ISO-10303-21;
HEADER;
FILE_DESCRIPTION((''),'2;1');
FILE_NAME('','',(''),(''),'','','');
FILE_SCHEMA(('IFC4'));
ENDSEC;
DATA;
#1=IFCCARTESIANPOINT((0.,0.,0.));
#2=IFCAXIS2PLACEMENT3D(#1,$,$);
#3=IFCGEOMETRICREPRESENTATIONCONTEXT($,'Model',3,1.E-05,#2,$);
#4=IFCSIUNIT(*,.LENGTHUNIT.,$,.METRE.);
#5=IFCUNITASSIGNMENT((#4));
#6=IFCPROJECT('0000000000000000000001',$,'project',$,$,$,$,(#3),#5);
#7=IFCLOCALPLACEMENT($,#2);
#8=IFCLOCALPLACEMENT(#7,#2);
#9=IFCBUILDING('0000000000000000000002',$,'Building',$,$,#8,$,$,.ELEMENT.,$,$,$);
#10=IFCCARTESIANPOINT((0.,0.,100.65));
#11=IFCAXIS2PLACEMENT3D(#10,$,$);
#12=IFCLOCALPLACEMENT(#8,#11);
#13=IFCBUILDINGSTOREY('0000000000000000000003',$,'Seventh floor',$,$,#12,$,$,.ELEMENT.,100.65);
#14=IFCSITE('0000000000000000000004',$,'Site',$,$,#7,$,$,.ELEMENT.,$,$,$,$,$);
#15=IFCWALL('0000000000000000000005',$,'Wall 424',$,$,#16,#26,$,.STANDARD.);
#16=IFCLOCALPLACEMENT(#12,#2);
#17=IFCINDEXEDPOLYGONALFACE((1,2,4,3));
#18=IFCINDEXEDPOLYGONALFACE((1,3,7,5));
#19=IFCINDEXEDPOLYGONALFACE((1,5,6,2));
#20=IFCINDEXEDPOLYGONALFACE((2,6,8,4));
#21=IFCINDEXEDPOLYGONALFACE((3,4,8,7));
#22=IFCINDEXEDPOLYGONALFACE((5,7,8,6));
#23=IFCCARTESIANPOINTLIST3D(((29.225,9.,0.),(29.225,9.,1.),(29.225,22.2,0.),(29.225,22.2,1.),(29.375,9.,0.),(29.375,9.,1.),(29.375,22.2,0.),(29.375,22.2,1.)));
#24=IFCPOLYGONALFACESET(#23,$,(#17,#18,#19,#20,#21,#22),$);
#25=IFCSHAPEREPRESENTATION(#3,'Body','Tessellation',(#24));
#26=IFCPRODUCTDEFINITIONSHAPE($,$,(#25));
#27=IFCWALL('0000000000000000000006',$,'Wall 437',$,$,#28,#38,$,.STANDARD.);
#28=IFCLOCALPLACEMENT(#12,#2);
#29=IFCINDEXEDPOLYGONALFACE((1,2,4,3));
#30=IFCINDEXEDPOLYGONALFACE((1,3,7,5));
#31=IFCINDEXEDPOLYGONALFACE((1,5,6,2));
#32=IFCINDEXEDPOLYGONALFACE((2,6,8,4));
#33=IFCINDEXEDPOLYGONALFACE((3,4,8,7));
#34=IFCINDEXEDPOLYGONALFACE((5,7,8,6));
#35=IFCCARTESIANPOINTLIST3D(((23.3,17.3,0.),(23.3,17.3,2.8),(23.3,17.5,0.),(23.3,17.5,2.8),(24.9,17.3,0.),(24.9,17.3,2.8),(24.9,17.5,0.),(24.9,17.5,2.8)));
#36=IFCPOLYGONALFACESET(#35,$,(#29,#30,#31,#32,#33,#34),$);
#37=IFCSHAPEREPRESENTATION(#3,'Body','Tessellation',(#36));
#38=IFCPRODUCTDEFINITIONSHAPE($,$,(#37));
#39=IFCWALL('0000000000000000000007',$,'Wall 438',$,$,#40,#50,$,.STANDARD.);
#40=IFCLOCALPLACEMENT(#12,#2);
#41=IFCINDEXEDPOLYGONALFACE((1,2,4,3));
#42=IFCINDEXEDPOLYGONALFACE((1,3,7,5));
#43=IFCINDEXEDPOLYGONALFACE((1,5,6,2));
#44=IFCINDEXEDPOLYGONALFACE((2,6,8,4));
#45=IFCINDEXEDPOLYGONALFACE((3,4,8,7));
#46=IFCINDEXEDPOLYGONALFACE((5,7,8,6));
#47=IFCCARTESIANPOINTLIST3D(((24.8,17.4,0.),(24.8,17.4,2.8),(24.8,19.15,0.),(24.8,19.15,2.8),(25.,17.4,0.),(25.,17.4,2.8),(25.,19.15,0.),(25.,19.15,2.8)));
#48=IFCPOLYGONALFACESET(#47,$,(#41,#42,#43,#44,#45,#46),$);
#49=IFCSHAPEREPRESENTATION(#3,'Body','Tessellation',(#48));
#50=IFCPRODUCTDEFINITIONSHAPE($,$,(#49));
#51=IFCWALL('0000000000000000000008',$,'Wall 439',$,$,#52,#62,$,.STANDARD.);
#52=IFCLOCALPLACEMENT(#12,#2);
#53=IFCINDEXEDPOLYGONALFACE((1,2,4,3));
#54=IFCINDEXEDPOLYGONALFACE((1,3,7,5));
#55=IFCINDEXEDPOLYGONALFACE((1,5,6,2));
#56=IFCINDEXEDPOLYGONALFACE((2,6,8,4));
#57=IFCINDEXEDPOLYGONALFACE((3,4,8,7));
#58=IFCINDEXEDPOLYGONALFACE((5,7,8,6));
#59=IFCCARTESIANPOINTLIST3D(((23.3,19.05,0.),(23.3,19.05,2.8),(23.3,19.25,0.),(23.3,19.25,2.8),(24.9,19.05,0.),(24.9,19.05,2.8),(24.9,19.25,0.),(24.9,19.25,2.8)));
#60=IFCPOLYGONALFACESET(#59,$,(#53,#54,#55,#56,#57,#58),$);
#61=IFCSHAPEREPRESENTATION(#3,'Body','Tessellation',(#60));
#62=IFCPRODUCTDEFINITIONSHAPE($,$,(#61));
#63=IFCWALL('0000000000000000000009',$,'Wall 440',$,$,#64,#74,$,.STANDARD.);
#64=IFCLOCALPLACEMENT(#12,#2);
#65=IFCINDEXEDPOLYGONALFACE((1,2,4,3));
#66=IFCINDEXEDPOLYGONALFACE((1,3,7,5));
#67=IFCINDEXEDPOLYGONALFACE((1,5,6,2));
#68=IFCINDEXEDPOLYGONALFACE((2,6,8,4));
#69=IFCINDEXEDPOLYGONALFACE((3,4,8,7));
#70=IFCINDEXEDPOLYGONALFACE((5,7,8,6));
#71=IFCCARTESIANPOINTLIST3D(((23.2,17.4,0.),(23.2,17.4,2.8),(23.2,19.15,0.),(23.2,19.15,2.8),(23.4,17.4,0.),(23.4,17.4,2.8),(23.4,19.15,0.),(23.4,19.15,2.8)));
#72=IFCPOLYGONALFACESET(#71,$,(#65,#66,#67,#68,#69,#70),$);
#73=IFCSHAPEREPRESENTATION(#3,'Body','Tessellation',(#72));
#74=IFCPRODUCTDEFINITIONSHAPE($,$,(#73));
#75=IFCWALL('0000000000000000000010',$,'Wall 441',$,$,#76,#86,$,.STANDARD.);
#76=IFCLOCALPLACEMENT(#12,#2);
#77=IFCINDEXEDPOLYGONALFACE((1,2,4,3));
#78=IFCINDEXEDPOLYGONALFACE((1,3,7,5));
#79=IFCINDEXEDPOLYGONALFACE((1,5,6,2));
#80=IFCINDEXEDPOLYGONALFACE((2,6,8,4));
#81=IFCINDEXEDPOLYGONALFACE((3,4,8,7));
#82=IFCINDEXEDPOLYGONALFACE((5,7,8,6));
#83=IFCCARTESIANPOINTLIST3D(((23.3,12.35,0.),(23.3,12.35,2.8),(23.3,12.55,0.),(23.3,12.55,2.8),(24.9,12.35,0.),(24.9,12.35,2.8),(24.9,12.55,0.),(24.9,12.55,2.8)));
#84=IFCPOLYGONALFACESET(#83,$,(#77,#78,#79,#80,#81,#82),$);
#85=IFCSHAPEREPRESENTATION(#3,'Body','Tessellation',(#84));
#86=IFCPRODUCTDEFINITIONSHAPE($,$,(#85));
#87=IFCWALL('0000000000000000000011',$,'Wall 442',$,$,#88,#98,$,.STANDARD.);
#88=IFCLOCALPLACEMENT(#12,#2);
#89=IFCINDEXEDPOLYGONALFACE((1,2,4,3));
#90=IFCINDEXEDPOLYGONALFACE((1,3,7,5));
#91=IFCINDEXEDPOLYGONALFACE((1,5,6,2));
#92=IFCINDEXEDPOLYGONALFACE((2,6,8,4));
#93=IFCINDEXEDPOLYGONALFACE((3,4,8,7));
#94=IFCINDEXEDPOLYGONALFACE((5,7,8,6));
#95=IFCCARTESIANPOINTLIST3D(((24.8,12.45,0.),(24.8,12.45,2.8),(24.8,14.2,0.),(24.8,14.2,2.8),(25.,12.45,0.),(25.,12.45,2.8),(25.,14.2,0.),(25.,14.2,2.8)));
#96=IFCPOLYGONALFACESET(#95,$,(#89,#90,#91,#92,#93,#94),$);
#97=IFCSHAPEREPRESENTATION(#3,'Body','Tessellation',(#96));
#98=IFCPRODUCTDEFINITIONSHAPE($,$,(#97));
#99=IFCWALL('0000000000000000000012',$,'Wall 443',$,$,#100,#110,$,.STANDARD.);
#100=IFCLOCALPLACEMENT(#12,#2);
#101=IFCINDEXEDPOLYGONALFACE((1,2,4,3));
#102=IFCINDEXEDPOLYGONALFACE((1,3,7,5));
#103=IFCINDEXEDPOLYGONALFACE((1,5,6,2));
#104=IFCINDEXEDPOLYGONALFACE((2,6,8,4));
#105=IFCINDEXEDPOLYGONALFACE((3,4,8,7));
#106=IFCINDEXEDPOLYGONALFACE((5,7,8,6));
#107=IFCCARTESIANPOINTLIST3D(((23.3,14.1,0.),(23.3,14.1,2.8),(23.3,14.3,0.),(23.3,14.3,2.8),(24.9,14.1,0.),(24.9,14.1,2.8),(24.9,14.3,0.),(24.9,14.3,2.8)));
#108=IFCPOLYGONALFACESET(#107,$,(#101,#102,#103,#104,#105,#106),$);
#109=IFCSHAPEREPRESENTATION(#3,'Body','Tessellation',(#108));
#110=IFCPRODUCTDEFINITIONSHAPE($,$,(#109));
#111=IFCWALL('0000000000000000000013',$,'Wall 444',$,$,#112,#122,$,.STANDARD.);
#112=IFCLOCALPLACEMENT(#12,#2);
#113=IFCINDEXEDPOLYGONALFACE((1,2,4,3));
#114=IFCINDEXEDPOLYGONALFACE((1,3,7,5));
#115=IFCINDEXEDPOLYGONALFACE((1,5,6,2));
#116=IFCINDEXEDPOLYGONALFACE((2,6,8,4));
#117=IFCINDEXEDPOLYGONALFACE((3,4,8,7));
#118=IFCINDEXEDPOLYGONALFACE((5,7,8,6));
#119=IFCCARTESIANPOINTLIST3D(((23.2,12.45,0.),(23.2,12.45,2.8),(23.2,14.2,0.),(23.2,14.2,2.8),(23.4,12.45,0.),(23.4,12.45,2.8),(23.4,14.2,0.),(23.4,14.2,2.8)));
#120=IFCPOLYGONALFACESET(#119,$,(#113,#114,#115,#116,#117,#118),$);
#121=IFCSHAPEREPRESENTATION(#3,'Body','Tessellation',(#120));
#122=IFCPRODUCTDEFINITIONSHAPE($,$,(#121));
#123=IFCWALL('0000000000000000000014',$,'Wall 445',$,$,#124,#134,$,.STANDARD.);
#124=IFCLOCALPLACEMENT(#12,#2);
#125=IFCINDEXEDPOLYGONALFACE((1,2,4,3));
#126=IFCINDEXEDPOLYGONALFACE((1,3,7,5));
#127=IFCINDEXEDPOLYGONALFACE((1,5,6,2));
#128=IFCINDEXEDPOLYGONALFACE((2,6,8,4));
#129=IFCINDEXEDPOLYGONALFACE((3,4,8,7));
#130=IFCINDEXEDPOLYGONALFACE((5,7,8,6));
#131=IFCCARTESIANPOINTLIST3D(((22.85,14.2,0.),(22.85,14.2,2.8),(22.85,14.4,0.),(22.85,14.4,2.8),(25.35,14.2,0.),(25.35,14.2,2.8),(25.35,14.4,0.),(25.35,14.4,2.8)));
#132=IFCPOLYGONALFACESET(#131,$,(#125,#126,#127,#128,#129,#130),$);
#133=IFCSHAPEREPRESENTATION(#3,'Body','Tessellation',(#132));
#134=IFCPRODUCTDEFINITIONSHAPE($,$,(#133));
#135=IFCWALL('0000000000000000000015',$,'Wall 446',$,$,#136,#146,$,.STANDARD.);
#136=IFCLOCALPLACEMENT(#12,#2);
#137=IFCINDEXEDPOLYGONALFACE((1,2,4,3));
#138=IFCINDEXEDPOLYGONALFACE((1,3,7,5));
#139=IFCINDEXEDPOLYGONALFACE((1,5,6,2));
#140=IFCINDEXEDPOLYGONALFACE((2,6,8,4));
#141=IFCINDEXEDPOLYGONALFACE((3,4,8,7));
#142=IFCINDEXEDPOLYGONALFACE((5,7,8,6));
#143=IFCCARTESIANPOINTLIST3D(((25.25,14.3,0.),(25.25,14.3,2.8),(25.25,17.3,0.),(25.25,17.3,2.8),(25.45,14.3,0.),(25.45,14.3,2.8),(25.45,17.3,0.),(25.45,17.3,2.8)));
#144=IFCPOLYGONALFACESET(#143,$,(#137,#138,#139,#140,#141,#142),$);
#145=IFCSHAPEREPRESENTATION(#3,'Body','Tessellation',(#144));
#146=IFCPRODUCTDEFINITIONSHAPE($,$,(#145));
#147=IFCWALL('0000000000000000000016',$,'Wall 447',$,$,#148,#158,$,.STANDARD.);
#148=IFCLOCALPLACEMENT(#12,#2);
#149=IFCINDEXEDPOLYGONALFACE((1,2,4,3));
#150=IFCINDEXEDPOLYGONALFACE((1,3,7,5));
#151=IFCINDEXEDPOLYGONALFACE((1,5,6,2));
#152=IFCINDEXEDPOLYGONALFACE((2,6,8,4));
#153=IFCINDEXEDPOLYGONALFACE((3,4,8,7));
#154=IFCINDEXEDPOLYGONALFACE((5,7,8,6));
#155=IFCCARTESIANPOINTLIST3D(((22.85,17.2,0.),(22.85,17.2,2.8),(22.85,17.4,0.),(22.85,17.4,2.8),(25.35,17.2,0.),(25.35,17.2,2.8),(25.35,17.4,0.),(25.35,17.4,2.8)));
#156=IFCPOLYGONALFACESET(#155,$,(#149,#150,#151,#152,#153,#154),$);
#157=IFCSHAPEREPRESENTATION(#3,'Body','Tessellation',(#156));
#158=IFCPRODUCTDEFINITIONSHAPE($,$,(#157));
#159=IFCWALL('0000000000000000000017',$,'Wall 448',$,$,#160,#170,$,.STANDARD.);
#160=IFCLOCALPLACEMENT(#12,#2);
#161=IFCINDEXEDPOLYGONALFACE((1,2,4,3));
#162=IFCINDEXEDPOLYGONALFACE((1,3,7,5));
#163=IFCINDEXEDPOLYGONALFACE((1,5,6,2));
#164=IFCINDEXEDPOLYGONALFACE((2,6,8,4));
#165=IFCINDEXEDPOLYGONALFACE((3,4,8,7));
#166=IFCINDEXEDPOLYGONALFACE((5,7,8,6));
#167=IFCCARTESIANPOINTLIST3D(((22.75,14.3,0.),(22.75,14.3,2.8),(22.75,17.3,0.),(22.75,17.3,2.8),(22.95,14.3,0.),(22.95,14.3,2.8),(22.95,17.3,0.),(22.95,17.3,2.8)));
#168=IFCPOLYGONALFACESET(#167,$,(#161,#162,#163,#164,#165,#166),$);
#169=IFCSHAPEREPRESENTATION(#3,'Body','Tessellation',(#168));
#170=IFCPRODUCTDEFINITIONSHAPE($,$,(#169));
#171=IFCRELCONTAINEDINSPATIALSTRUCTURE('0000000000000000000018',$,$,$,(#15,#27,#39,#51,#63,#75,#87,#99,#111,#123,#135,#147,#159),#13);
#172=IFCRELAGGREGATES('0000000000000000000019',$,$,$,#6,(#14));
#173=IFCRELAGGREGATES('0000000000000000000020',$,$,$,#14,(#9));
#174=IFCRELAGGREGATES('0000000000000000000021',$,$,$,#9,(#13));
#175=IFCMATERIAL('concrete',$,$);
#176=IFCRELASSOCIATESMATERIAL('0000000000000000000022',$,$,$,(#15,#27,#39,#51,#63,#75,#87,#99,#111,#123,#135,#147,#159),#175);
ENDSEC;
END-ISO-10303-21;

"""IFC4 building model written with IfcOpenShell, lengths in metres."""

from ifc_helpers import new_model, si_unit, frame, frame_2d, origin, place, context, project, spatial, rectangle, extrude, material, element, save


model = new_model("IFC4")

# Units and contexts
model_context = context("Model", 3, precision=1e-05, world=origin())
ifc_project = project(units=[si_unit("LENGTHUNIT", "METRE")], contexts=[model_context])

# Site, building, storey
site_placement = place(None, origin())
site = spatial("IfcSite", under=ifc_project, at=site_placement, Name="Site", CompositionType="ELEMENT")
building_placement = place(site_placement, origin())
building = spatial("IfcBuilding", under=site, at=building_placement, Name="Building", CompositionType="ELEMENT")
storey_placement = place(building_placement, frame((0.0, 0.0, 100.65)))
storey = spatial("IfcBuildingStorey", under=building, at=storey_placement, Name="Seventh floor", CompositionType="ELEMENT", Elevation=100.65)

# Shared definitions
ifc_material = material(Name="concrete")

# Walls
wall_1_placement = place(storey_placement, frame((29.3, 22.2, 0.0), z_axis=(0.0, 0.0, 1.0), x_axis=(0.0, -1.0, 0.0)))
element("IfcWall", 1, at=wall_1_placement, inside=storey, material=ifc_material, Name="Wall 424", PredefinedType="STANDARD", context=model_context, shape_type="SweptSolid", body=[
    extrude(rectangle(XDim=13.2, YDim=0.15, at=frame_2d((6.6, 0.0))), origin(), (0.0, 0.0, 1.0), 1.0),
])
wall_2_placement = place(storey_placement, frame((23.3, 17.4, 0.0), z_axis=(0.0, 0.0, 1.0), x_axis=(1.0, 0.0, 0.0)))
element("IfcWall", 2, at=wall_2_placement, inside=storey, material=ifc_material, Name="Wall 437", PredefinedType="STANDARD", context=model_context, shape_type="SweptSolid", body=[
    extrude(rectangle(XDim=1.6, YDim=0.2, at=frame_2d((0.8, 0.0))), origin(), (0.0, 0.0, 1.0), 2.8),
])
wall_3_placement = place(storey_placement, frame((24.9, 17.4, 0.0), z_axis=(0.0, 0.0, 1.0), x_axis=(0.0, 1.0, 0.0)))
element("IfcWall", 3, at=wall_3_placement, inside=storey, material=ifc_material, Name="Wall 438", PredefinedType="STANDARD", context=model_context, shape_type="SweptSolid", body=[
    extrude(rectangle(XDim=1.75, YDim=0.2, at=frame_2d((0.875, 0.0))), origin(), (0.0, 0.0, 1.0), 2.8),
])
wall_4_placement = place(storey_placement, frame((24.9, 19.15, 0.0), z_axis=(0.0, 0.0, 1.0), x_axis=(-1.0, 0.0, 0.0)))
element("IfcWall", 4, at=wall_4_placement, inside=storey, material=ifc_material, Name="Wall 439", PredefinedType="STANDARD", context=model_context, shape_type="SweptSolid", body=[
    extrude(rectangle(XDim=1.6, YDim=0.2, at=frame_2d((0.8, 0.0))), origin(), (0.0, 0.0, 1.0), 2.8),
])
wall_5_placement = place(storey_placement, frame((23.3, 19.15, 0.0), z_axis=(0.0, 0.0, 1.0), x_axis=(0.0, -1.0, 0.0)))
element("IfcWall", 5, at=wall_5_placement, inside=storey, material=ifc_material, Name="Wall 440", PredefinedType="STANDARD", context=model_context, shape_type="SweptSolid", body=[
    extrude(rectangle(XDim=1.75, YDim=0.2, at=frame_2d((0.875, 0.0))), origin(), (0.0, 0.0, 1.0), 2.8),
])
wall_6_placement = place(storey_placement, frame((23.3, 12.45, 0.0), z_axis=(0.0, 0.0, 1.0), x_axis=(1.0, 0.0, 0.0)))
element("IfcWall", 6, at=wall_6_placement, inside=storey, material=ifc_material, Name="Wall 441", PredefinedType="STANDARD", context=model_context, shape_type="SweptSolid", body=[
    extrude(rectangle(XDim=1.6, YDim=0.2, at=frame_2d((0.8, 0.0))), origin(), (0.0, 0.0, 1.0), 2.8),
])
wall_7_placement = place(storey_placement, frame((24.9, 12.45, 0.0), z_axis=(0.0, 0.0, 1.0), x_axis=(0.0, 1.0, 0.0)))
element("IfcWall", 7, at=wall_7_placement, inside=storey, material=ifc_material, Name="Wall 442", PredefinedType="STANDARD", context=model_context, shape_type="SweptSolid", body=[
    extrude(rectangle(XDim=1.75, YDim=0.2, at=frame_2d((0.875, 0.0))), origin(), (0.0, 0.0, 1.0), 2.8),
])
wall_8_placement = place(storey_placement, frame((24.9, 14.2, 0.0), z_axis=(0.0, 0.0, 1.0), x_axis=(-1.0, 0.0, 0.0)))
element("IfcWall", 8, at=wall_8_placement, inside=storey, material=ifc_material, Name="Wall 443", PredefinedType="STANDARD", context=model_context, shape_type="SweptSolid", body=[
    extrude(rectangle(XDim=1.6, YDim=0.2, at=frame_2d((0.8, 0.0))), origin(), (0.0, 0.0, 1.0), 2.8),
])
wall_9_placement = place(storey_placement, frame((23.3, 14.2, 0.0), z_axis=(0.0, 0.0, 1.0), x_axis=(0.0, -1.0, 0.0)))
element("IfcWall", 9, at=wall_9_placement, inside=storey, material=ifc_material, Name="Wall 444", PredefinedType="STANDARD", context=model_context, shape_type="SweptSolid", body=[
    extrude(rectangle(XDim=1.75, YDim=0.2, at=frame_2d((0.875, 0.0))), origin(), (0.0, 0.0, 1.0), 2.8),
])
wall_10_placement = place(storey_placement, frame((22.85, 14.3, 0.0), z_axis=(0.0, 0.0, 1.0), x_axis=(1.0, 0.0, 0.0)))
element("IfcWall", 10, at=wall_10_placement, inside=storey, material=ifc_material, Name="Wall 445", PredefinedType="STANDARD", context=model_context, shape_type="SweptSolid", body=[
    extrude(rectangle(XDim=2.5, YDim=0.2, at=frame_2d((1.25, 0.0))), origin(), (0.0, 0.0, 1.0), 2.8),
])
wall_11_placement = place(storey_placement, frame((25.35, 14.3, 0.0), z_axis=(0.0, 0.0, 1.0), x_axis=(0.0, 1.0, 0.0)))
element("IfcWall", 11, at=wall_11_placement, inside=storey, material=ifc_material, Name="Wall 446", PredefinedType="STANDARD", context=model_context, shape_type="SweptSolid", body=[
    extrude(rectangle(XDim=3.0, YDim=0.2, at=frame_2d((1.5, 0.0))), origin(), (0.0, 0.0, 1.0), 2.8),
])
wall_12_placement = place(storey_placement, frame((25.35, 17.3, 0.0), z_axis=(0.0, 0.0, 1.0), x_axis=(-1.0, 0.0, 0.0)))
element("IfcWall", 12, at=wall_12_placement, inside=storey, material=ifc_material, Name="Wall 447", PredefinedType="STANDARD", context=model_context, shape_type="SweptSolid", body=[
    extrude(rectangle(XDim=2.5, YDim=0.2, at=frame_2d((1.25, 0.0))), origin(), (0.0, 0.0, 1.0), 2.8),
])
wall_13_placement = place(storey_placement, frame((22.85, 17.3, 0.0), z_axis=(0.0, 0.0, 1.0), x_axis=(0.0, -1.0, 0.0)))
element("IfcWall", 13, at=wall_13_placement, inside=storey, material=ifc_material, Name="Wall 448", PredefinedType="STANDARD", context=model_context, shape_type="SweptSolid", body=[
    extrude(rectangle(XDim=3.0, YDim=0.2, at=frame_2d((1.5, 0.0))), origin(), (0.0, 0.0, 1.0), 2.8),
])

save(model, "model.ifc")
